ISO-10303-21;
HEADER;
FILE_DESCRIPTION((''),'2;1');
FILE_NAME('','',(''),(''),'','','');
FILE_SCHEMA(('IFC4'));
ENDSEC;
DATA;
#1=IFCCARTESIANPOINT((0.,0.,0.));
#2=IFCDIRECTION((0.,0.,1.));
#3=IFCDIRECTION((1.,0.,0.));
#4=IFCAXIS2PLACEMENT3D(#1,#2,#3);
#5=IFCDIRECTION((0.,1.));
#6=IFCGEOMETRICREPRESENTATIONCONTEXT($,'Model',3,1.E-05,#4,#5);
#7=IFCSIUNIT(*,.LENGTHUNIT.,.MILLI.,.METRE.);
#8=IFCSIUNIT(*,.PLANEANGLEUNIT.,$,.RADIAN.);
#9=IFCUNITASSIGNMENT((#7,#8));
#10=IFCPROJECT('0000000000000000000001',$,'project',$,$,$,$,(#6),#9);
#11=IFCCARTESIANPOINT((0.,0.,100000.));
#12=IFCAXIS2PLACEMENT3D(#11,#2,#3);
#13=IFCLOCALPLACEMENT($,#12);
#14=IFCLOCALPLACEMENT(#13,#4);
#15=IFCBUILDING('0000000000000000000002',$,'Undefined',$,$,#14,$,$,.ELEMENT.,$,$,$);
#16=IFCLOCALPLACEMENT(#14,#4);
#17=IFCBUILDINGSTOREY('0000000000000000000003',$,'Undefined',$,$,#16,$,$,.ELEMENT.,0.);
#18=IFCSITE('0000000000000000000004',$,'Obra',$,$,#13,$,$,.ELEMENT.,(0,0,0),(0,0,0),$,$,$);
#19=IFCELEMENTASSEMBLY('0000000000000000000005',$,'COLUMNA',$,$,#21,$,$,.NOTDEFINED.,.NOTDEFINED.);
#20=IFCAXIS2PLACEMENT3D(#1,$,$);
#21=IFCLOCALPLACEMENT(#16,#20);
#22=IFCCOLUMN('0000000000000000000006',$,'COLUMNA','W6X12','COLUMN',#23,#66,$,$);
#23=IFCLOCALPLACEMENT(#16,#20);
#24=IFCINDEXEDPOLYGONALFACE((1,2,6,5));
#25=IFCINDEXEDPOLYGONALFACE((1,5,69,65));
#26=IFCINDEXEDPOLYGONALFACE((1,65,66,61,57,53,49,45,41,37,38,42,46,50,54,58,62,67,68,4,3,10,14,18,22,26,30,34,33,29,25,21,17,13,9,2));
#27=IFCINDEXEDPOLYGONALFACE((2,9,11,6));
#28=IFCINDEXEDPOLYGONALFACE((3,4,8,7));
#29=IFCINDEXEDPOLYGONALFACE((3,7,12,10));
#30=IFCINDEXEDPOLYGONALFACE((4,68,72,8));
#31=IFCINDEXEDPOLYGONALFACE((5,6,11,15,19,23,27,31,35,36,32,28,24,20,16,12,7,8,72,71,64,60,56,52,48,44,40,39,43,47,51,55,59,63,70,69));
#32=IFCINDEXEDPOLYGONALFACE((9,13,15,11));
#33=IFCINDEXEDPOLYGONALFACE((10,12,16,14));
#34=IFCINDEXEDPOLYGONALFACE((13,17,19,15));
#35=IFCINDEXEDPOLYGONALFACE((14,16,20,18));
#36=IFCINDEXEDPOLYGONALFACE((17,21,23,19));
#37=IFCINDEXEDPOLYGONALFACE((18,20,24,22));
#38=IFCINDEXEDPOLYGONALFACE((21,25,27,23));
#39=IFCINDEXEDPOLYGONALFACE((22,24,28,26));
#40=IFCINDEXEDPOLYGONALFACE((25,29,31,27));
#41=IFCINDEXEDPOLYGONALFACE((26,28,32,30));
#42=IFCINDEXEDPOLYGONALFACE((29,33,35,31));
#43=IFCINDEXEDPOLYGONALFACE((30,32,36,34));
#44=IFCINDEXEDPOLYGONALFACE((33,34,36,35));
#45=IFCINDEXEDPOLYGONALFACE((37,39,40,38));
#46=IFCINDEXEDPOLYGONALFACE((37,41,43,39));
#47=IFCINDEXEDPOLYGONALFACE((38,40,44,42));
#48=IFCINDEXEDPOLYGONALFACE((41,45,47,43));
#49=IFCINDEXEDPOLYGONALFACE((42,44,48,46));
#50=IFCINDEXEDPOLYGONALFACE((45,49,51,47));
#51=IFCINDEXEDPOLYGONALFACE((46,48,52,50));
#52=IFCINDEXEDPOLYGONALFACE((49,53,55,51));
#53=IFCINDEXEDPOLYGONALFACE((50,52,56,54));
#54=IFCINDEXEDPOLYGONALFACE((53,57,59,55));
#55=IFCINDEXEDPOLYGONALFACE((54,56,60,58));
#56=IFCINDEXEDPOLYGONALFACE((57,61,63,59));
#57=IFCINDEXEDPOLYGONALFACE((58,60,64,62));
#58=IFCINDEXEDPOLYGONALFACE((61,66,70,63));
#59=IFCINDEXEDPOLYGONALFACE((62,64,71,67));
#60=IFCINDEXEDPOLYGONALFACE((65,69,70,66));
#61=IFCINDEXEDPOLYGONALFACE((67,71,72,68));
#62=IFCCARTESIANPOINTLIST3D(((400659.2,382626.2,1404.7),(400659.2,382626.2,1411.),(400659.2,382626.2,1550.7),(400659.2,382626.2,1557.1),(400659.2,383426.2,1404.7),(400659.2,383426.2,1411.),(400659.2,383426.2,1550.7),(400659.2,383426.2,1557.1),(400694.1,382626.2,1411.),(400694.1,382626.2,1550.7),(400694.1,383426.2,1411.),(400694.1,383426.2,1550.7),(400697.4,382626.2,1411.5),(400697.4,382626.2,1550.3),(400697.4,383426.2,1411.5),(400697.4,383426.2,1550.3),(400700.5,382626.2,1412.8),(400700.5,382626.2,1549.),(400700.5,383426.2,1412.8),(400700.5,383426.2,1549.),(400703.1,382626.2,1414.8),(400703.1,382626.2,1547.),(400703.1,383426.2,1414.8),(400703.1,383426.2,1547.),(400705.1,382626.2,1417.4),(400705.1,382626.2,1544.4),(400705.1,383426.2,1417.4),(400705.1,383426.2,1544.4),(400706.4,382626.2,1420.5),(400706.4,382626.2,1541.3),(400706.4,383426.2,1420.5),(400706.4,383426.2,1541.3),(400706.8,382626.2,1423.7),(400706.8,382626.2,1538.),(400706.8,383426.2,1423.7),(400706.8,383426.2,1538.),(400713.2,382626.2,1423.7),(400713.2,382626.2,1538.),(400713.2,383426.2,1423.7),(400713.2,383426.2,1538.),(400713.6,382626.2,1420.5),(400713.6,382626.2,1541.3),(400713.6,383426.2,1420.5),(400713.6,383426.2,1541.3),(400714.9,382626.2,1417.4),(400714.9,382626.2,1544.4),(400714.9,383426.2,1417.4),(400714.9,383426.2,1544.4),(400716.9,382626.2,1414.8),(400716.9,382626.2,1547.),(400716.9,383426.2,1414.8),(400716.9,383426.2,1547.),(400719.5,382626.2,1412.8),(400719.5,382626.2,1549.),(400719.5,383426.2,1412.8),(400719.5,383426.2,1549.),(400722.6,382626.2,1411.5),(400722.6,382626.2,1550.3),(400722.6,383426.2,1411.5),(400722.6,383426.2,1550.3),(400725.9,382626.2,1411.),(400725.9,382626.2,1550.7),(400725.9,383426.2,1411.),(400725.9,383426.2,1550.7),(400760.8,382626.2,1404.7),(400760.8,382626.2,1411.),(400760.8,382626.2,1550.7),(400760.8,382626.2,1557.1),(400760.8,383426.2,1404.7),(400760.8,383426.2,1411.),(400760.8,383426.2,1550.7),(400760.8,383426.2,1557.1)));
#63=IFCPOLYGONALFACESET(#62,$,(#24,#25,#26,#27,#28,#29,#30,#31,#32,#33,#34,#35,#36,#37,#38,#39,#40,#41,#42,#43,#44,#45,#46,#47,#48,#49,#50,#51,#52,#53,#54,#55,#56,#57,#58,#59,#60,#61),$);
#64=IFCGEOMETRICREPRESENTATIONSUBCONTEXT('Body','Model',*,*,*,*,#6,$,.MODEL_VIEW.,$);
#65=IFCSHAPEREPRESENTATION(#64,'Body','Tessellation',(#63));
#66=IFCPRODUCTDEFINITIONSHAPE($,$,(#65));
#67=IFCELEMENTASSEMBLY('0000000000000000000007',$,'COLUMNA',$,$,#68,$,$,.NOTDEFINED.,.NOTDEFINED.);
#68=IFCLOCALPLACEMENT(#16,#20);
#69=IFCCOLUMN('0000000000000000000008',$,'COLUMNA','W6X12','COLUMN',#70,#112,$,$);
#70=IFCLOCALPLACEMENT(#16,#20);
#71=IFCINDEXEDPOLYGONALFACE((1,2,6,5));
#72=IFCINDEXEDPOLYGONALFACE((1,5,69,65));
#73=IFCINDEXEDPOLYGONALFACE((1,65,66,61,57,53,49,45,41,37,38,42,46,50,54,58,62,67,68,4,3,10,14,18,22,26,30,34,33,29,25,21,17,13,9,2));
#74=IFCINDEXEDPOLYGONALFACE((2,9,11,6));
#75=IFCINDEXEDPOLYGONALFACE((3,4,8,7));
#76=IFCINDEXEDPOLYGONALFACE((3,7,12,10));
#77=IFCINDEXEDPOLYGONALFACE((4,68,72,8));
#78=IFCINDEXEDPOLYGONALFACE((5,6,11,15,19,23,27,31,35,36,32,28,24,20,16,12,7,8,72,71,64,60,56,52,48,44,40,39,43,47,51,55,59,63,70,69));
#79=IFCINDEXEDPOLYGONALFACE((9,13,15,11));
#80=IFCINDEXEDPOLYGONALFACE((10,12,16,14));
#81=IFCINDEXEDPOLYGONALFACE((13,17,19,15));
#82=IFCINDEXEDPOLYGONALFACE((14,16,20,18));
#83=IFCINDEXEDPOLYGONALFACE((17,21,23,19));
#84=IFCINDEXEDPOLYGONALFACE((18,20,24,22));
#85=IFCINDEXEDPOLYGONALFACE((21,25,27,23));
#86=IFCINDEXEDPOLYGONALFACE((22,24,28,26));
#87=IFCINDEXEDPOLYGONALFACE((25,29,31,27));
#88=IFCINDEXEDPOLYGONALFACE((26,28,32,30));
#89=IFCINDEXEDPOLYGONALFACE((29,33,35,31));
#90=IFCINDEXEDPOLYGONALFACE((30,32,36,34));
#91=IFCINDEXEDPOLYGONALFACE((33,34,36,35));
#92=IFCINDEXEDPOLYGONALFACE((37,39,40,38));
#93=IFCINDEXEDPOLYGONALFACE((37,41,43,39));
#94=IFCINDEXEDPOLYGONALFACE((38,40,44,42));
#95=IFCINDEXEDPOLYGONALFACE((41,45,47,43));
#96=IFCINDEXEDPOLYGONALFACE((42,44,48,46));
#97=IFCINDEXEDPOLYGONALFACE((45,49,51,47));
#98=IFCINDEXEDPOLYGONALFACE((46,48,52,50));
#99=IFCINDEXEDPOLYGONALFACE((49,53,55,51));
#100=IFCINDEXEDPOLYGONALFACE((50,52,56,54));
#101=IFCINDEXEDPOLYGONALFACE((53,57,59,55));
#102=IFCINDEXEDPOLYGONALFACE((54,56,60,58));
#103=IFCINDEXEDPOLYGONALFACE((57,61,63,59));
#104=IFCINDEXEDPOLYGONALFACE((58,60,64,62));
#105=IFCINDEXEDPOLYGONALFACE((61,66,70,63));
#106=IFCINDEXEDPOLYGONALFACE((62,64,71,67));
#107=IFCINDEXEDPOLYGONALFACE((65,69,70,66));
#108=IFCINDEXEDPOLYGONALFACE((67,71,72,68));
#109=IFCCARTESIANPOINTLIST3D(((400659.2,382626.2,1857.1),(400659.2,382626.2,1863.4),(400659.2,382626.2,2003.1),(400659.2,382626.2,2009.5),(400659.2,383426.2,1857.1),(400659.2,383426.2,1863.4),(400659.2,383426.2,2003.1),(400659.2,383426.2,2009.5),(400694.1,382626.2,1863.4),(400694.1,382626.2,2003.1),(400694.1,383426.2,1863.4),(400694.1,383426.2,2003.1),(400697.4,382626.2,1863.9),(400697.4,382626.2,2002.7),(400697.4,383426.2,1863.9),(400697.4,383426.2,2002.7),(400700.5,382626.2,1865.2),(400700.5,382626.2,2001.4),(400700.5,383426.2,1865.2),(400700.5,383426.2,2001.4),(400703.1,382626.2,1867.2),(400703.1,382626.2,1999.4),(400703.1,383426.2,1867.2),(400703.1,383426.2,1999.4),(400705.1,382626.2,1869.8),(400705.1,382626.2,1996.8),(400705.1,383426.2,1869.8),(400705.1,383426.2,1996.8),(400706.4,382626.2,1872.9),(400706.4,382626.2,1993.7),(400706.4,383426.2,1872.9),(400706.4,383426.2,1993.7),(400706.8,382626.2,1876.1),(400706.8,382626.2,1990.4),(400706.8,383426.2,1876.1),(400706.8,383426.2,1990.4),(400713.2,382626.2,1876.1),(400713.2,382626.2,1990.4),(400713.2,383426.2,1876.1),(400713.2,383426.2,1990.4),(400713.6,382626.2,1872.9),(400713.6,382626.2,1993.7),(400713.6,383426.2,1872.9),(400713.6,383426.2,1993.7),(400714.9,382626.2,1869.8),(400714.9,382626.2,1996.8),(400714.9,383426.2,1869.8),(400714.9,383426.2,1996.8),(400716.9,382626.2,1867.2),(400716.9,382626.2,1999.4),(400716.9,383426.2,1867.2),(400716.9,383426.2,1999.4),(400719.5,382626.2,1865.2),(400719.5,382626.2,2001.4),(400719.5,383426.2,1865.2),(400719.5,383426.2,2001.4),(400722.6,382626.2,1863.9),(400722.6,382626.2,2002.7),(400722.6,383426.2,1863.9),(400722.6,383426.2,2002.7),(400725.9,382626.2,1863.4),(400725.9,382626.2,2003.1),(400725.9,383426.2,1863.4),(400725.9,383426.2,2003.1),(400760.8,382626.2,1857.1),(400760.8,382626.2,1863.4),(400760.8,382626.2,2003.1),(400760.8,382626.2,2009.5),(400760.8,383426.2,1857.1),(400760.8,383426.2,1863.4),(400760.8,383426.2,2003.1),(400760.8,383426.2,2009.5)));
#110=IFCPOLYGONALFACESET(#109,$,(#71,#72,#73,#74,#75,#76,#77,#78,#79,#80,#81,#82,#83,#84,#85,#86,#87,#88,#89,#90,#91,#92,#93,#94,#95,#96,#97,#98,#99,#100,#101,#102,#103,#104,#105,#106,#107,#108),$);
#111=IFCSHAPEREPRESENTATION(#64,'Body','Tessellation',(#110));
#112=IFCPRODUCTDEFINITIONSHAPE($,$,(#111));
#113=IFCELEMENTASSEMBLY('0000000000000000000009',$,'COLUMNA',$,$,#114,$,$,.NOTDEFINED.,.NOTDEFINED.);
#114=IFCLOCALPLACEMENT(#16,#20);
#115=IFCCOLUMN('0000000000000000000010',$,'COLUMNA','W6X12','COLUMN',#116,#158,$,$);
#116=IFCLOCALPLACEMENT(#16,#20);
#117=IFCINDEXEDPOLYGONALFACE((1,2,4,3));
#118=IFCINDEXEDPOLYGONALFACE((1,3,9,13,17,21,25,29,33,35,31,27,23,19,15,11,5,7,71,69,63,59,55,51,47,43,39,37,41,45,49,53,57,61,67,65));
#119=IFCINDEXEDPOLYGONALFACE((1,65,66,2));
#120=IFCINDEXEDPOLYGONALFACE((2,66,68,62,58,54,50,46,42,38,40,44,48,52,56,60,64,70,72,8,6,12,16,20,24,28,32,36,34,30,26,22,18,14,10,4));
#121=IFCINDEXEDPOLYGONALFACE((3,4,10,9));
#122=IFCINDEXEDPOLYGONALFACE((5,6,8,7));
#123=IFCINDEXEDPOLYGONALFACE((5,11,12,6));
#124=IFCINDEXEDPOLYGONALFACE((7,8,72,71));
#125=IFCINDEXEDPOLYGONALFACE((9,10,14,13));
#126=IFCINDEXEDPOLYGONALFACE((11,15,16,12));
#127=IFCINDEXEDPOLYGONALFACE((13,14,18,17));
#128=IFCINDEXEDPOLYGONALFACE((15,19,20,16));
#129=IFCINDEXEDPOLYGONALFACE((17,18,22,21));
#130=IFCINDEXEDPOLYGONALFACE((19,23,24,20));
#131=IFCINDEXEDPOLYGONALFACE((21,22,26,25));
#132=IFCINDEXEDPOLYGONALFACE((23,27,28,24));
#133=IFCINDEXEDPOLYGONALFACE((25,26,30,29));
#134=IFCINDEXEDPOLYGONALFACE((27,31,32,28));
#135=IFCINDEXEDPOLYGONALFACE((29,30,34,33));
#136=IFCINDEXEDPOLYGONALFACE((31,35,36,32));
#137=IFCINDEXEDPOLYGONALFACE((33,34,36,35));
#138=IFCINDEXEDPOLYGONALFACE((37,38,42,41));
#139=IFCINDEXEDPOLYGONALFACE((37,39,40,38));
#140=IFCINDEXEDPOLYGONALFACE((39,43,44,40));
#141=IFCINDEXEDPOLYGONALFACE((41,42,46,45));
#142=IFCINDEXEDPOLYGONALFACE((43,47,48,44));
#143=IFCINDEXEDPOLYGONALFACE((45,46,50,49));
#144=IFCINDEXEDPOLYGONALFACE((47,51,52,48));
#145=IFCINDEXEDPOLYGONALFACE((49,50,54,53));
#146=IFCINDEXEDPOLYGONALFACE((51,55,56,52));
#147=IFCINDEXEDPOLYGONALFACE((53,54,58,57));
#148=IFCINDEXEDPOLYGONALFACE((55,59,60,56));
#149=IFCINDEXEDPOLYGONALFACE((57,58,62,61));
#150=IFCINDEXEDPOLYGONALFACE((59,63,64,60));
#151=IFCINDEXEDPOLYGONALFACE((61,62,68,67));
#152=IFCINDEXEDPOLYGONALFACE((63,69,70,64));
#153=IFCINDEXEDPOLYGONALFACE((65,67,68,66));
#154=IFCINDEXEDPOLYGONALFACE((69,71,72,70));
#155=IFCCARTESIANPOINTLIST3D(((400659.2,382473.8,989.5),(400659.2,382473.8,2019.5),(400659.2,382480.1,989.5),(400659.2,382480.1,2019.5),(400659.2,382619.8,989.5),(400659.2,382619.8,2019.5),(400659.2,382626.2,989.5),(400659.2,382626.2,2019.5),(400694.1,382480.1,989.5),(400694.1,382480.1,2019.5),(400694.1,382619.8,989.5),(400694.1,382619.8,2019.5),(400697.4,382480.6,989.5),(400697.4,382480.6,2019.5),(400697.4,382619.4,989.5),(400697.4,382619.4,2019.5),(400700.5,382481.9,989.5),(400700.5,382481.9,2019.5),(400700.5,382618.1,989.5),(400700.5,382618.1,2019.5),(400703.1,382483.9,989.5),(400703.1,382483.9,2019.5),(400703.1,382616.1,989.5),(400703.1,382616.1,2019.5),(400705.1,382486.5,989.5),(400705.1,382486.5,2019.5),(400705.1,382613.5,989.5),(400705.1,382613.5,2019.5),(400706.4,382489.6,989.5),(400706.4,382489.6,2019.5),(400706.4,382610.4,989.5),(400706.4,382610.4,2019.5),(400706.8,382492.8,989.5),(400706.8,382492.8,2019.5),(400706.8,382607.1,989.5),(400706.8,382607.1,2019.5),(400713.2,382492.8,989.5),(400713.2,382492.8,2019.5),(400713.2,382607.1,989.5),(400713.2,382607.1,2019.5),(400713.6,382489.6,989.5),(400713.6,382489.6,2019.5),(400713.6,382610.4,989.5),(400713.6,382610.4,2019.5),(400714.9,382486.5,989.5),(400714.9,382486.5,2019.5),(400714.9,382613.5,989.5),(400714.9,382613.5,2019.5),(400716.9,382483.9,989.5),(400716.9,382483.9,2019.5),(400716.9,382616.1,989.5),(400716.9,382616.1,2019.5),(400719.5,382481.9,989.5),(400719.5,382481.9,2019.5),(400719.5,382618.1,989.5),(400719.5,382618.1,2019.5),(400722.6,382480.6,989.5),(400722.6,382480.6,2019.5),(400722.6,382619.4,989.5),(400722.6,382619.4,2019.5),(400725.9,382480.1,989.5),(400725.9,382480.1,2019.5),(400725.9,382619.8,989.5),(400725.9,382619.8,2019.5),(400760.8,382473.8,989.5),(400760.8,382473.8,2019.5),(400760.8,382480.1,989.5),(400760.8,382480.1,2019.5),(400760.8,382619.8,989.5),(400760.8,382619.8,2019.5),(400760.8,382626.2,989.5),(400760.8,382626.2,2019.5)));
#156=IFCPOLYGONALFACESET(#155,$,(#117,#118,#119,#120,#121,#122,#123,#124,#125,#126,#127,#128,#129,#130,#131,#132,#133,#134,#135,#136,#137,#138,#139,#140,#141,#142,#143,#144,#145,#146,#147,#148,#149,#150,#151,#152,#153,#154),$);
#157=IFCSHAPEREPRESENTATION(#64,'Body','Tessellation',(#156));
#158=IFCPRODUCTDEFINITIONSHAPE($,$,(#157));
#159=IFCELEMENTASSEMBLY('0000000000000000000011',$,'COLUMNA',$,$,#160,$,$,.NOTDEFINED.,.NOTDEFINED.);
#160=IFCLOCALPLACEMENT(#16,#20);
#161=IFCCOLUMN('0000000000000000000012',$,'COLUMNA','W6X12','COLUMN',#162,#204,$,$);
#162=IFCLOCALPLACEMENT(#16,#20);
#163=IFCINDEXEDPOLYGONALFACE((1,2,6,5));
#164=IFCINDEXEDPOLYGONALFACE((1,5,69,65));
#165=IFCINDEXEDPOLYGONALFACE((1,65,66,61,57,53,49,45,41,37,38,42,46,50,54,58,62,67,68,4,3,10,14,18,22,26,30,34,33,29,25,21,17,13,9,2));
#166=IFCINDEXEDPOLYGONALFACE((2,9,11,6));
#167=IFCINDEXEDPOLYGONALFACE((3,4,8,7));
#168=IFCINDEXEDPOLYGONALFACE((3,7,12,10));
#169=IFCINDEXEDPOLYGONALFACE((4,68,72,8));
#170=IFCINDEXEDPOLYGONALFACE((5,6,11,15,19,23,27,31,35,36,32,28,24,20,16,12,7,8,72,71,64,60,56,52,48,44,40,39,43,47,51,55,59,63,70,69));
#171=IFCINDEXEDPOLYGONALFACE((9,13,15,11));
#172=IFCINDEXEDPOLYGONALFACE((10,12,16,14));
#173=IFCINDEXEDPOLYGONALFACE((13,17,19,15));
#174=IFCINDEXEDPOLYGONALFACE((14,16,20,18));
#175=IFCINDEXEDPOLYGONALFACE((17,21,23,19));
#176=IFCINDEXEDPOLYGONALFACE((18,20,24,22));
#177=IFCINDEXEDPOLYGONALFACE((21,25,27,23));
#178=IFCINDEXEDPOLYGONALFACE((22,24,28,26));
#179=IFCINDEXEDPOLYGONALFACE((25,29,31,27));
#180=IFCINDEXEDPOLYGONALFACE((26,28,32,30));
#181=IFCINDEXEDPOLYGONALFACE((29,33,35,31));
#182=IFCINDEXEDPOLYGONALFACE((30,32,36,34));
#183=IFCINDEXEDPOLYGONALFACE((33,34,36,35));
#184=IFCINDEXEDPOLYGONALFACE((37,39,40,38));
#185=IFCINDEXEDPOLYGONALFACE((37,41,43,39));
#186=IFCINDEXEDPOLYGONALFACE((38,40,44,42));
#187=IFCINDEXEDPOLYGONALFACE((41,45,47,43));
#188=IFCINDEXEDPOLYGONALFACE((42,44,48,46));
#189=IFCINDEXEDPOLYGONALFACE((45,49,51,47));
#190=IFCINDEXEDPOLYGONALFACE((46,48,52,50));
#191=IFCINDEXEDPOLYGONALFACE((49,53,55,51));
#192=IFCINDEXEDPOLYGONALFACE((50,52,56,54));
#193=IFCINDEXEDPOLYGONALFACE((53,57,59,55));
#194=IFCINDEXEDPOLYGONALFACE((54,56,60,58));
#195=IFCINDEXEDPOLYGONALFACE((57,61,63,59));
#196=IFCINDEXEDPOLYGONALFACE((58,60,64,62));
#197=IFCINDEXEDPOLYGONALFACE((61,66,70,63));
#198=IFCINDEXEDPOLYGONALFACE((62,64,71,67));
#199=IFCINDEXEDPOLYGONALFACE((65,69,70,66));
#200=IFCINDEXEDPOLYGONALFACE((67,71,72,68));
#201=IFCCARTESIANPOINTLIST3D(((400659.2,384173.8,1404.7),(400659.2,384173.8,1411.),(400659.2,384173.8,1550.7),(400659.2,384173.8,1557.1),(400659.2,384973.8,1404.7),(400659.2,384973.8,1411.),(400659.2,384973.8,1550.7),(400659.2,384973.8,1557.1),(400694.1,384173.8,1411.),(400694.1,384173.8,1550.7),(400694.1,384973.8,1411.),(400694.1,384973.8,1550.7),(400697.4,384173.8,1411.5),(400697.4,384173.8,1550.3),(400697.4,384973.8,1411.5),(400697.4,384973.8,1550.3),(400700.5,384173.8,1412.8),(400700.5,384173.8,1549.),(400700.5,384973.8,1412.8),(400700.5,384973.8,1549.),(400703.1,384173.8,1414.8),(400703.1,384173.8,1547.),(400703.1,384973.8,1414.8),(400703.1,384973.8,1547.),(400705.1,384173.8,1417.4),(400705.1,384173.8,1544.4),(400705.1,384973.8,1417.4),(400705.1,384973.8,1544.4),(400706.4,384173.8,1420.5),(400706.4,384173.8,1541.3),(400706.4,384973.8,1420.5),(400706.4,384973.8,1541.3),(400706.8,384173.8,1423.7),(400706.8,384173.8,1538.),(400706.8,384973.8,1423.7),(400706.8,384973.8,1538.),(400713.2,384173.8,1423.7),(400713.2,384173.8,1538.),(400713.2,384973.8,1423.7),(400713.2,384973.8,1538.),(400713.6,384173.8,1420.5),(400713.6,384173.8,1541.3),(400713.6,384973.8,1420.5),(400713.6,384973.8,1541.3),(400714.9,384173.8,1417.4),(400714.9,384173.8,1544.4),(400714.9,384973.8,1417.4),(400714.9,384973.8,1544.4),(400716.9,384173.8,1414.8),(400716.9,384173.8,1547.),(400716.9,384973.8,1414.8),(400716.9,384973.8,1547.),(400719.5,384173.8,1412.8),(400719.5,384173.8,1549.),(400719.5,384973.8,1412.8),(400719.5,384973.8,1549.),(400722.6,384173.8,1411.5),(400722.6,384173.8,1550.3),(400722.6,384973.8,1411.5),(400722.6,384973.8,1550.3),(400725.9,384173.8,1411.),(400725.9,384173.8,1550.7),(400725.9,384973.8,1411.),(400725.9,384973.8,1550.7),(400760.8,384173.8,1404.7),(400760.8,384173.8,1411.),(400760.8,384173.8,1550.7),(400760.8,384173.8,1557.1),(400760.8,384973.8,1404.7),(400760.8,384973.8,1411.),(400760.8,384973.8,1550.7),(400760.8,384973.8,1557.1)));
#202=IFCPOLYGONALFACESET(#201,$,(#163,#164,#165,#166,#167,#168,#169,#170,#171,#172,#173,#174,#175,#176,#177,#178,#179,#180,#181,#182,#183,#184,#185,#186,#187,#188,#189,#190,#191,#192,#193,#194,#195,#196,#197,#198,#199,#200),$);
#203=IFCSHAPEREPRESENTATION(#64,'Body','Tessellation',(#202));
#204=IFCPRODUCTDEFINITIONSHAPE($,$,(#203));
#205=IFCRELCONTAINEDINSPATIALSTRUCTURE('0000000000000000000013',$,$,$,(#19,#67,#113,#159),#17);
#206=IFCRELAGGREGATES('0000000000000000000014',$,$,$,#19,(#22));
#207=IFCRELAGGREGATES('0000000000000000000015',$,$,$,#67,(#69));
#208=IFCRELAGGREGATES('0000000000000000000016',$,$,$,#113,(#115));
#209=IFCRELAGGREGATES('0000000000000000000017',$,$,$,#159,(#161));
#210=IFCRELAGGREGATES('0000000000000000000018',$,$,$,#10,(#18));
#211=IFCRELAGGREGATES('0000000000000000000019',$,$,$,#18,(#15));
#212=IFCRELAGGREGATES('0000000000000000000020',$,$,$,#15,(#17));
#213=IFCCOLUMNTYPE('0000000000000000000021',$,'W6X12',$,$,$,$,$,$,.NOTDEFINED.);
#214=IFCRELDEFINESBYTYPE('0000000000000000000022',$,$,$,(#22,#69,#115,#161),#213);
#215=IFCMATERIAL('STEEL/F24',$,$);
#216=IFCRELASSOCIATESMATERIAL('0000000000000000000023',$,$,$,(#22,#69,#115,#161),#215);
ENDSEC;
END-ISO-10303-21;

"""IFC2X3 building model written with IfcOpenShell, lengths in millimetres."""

from ifc_helpers import new_model, si_unit, direction, frame, origin_with_axes, origin_2d_with_axis, place, context, subcontext, project, spatial, i_section, extrude, material, type_object, element, aggregate, save


model = new_model("IFC2X3")

# Units and contexts
model_context = context("Model", 3, precision=1e-05, world=origin_with_axes(), true_north=direction((0.0, 1.0)))
body_context = subcontext(model_context, "Body", "Model", "MODEL_VIEW")
ifc_project = project(units=[si_unit("LENGTHUNIT", "METRE", prefix="MILLI"), si_unit("PLANEANGLEUNIT", "RADIAN")], contexts=[model_context])

# Site, building, storey
site_placement = place(None, frame((0.0, 0.0, 100000.0), z_axis=(0.0, 0.0, 1.0), x_axis=(1.0, 0.0, 0.0)))
site = spatial("IfcSite", under=ifc_project, at=site_placement, Name="Obra", CompositionType="ELEMENT", RefLatitude=(0, 0, 0), RefLongitude=(0, 0, 0))
building_placement = place(site_placement, origin_with_axes())
building = spatial("IfcBuilding", under=site, at=building_placement, Name="Undefined", CompositionType="ELEMENT")
storey_placement = place(building_placement, origin_with_axes())
storey = spatial("IfcBuildingStorey", under=building, at=storey_placement, Name="Undefined", CompositionType="ELEMENT", Elevation=0.0)

# Element assemblies, columns
ifc_material_1 = material(Name="STEEL/F24")
assembly_1_placement = place(storey_placement, origin_with_axes())
assembly_1 = element("IfcElementAssembly", 1, at=assembly_1_placement, inside=storey, Name="COLUMNA", AssemblyPlace="NOTDEFINED", PredefinedType="NOTDEFINED")
column_type_1 = type_object("IfcColumnType", Name="W6X12", PredefinedType="NOTDEFINED")
column_1_placement = place(assembly_1_placement, frame((400710.0, 382626.2, 1480.9), z_axis=(0.0, 1.0, 0.0), x_axis=(0.0, 0.0, -1.0)))
column_1 = element("IfcColumn", 2, at=column_1_placement, type_object=column_type_1, material=ifc_material_1, Name="COLUMNA", Description="W6X12", ObjectType="COLUMN", context=body_context, shape_type="SweptSolid", body=[
    extrude(i_section(OverallWidth=101.6, OverallDepth=152.4, WebThickness=6.3, FlangeThickness=6.3, FilletRadius=12.7, at=origin_2d_with_axis()), frame((0.0, 0.0, 800.0), z_axis=(0.0, 0.0, -1.0), x_axis=(0.0, 1.0, 0.0)), (0.0, 0.0, 1.0), 800.0),
])
aggregate(assembly_1, [column_1])
assembly_2_placement = place(storey_placement, origin_with_axes())
assembly_2 = element("IfcElementAssembly", 3, at=assembly_2_placement, inside=storey, Name="COLUMNA", AssemblyPlace="NOTDEFINED", PredefinedType="NOTDEFINED")
column_2_placement = place(assembly_2_placement, frame((400710.0, 382626.2, 1933.3), z_axis=(0.0, 1.0, 0.0), x_axis=(0.0, 0.0, -1.0)))
column_2 = element("IfcColumn", 4, at=column_2_placement, type_object=column_type_1, material=ifc_material_1, Name="COLUMNA", Description="W6X12", ObjectType="COLUMN", context=body_context, shape_type="SweptSolid", body=[
    extrude(i_section(OverallWidth=101.6, OverallDepth=152.4, WebThickness=6.3, FlangeThickness=6.3, FilletRadius=12.7, at=origin_2d_with_axis()), frame((0.0, 0.0, 800.0), z_axis=(0.0, 0.0, -1.0), x_axis=(0.0, 1.0, 0.0)), (0.0, 0.0, 1.0), 800.0),
])
aggregate(assembly_2, [column_2])
assembly_3_placement = place(storey_placement, origin_with_axes())
assembly_3 = element("IfcElementAssembly", 5, at=assembly_3_placement, inside=storey, Name="COLUMNA", AssemblyPlace="NOTDEFINED", PredefinedType="NOTDEFINED")
column_3_placement = place(assembly_3_placement, frame((400710.0, 382550.0, 989.5), z_axis=(0.0, 0.0, 1.0), x_axis=(0.0, -1.0, 0.0)))
column_3 = element("IfcColumn", 6, at=column_3_placement, type_object=column_type_1, material=ifc_material_1, Name="COLUMNA", Description="W6X12", ObjectType="COLUMN", context=body_context, shape_type="SweptSolid", body=[
    extrude(i_section(OverallWidth=101.6, OverallDepth=152.4, WebThickness=6.3, FlangeThickness=6.3, FilletRadius=12.7, at=origin_2d_with_axis()), frame((0.0, 0.0, 1030.0), z_axis=(0.0, 0.0, -1.0), x_axis=(0.0, 1.0, 0.0)), (0.0, 0.0, 1.0), 1030.0),
])
aggregate(assembly_3, [column_3])
assembly_4_placement = place(storey_placement, origin_with_axes())
assembly_4 = element("IfcElementAssembly", 7, at=assembly_4_placement, inside=storey, Name="COLUMNA", AssemblyPlace="NOTDEFINED", PredefinedType="NOTDEFINED")
column_4_placement = place(assembly_4_placement, frame((400710.0, 384973.8, 1480.9), z_axis=(0.0, -1.0, 0.0), x_axis=(0.0, 0.0, -1.0)))
column_4 = element("IfcColumn", 8, at=column_4_placement, type_object=column_type_1, material=ifc_material_1, Name="COLUMNA", Description="W6X12", ObjectType="COLUMN", context=body_context, shape_type="SweptSolid", body=[
    extrude(i_section(OverallWidth=101.6, OverallDepth=152.4, WebThickness=6.3, FlangeThickness=6.3, FilletRadius=12.7, at=origin_2d_with_axis()), frame((0.0, 0.0, 800.0), z_axis=(0.0, 0.0, -1.0), x_axis=(0.0, 1.0, 0.0)), (0.0, 0.0, 1.0), 800.0),
])
aggregate(assembly_4, [column_4])

save(model, "model.ifc")
